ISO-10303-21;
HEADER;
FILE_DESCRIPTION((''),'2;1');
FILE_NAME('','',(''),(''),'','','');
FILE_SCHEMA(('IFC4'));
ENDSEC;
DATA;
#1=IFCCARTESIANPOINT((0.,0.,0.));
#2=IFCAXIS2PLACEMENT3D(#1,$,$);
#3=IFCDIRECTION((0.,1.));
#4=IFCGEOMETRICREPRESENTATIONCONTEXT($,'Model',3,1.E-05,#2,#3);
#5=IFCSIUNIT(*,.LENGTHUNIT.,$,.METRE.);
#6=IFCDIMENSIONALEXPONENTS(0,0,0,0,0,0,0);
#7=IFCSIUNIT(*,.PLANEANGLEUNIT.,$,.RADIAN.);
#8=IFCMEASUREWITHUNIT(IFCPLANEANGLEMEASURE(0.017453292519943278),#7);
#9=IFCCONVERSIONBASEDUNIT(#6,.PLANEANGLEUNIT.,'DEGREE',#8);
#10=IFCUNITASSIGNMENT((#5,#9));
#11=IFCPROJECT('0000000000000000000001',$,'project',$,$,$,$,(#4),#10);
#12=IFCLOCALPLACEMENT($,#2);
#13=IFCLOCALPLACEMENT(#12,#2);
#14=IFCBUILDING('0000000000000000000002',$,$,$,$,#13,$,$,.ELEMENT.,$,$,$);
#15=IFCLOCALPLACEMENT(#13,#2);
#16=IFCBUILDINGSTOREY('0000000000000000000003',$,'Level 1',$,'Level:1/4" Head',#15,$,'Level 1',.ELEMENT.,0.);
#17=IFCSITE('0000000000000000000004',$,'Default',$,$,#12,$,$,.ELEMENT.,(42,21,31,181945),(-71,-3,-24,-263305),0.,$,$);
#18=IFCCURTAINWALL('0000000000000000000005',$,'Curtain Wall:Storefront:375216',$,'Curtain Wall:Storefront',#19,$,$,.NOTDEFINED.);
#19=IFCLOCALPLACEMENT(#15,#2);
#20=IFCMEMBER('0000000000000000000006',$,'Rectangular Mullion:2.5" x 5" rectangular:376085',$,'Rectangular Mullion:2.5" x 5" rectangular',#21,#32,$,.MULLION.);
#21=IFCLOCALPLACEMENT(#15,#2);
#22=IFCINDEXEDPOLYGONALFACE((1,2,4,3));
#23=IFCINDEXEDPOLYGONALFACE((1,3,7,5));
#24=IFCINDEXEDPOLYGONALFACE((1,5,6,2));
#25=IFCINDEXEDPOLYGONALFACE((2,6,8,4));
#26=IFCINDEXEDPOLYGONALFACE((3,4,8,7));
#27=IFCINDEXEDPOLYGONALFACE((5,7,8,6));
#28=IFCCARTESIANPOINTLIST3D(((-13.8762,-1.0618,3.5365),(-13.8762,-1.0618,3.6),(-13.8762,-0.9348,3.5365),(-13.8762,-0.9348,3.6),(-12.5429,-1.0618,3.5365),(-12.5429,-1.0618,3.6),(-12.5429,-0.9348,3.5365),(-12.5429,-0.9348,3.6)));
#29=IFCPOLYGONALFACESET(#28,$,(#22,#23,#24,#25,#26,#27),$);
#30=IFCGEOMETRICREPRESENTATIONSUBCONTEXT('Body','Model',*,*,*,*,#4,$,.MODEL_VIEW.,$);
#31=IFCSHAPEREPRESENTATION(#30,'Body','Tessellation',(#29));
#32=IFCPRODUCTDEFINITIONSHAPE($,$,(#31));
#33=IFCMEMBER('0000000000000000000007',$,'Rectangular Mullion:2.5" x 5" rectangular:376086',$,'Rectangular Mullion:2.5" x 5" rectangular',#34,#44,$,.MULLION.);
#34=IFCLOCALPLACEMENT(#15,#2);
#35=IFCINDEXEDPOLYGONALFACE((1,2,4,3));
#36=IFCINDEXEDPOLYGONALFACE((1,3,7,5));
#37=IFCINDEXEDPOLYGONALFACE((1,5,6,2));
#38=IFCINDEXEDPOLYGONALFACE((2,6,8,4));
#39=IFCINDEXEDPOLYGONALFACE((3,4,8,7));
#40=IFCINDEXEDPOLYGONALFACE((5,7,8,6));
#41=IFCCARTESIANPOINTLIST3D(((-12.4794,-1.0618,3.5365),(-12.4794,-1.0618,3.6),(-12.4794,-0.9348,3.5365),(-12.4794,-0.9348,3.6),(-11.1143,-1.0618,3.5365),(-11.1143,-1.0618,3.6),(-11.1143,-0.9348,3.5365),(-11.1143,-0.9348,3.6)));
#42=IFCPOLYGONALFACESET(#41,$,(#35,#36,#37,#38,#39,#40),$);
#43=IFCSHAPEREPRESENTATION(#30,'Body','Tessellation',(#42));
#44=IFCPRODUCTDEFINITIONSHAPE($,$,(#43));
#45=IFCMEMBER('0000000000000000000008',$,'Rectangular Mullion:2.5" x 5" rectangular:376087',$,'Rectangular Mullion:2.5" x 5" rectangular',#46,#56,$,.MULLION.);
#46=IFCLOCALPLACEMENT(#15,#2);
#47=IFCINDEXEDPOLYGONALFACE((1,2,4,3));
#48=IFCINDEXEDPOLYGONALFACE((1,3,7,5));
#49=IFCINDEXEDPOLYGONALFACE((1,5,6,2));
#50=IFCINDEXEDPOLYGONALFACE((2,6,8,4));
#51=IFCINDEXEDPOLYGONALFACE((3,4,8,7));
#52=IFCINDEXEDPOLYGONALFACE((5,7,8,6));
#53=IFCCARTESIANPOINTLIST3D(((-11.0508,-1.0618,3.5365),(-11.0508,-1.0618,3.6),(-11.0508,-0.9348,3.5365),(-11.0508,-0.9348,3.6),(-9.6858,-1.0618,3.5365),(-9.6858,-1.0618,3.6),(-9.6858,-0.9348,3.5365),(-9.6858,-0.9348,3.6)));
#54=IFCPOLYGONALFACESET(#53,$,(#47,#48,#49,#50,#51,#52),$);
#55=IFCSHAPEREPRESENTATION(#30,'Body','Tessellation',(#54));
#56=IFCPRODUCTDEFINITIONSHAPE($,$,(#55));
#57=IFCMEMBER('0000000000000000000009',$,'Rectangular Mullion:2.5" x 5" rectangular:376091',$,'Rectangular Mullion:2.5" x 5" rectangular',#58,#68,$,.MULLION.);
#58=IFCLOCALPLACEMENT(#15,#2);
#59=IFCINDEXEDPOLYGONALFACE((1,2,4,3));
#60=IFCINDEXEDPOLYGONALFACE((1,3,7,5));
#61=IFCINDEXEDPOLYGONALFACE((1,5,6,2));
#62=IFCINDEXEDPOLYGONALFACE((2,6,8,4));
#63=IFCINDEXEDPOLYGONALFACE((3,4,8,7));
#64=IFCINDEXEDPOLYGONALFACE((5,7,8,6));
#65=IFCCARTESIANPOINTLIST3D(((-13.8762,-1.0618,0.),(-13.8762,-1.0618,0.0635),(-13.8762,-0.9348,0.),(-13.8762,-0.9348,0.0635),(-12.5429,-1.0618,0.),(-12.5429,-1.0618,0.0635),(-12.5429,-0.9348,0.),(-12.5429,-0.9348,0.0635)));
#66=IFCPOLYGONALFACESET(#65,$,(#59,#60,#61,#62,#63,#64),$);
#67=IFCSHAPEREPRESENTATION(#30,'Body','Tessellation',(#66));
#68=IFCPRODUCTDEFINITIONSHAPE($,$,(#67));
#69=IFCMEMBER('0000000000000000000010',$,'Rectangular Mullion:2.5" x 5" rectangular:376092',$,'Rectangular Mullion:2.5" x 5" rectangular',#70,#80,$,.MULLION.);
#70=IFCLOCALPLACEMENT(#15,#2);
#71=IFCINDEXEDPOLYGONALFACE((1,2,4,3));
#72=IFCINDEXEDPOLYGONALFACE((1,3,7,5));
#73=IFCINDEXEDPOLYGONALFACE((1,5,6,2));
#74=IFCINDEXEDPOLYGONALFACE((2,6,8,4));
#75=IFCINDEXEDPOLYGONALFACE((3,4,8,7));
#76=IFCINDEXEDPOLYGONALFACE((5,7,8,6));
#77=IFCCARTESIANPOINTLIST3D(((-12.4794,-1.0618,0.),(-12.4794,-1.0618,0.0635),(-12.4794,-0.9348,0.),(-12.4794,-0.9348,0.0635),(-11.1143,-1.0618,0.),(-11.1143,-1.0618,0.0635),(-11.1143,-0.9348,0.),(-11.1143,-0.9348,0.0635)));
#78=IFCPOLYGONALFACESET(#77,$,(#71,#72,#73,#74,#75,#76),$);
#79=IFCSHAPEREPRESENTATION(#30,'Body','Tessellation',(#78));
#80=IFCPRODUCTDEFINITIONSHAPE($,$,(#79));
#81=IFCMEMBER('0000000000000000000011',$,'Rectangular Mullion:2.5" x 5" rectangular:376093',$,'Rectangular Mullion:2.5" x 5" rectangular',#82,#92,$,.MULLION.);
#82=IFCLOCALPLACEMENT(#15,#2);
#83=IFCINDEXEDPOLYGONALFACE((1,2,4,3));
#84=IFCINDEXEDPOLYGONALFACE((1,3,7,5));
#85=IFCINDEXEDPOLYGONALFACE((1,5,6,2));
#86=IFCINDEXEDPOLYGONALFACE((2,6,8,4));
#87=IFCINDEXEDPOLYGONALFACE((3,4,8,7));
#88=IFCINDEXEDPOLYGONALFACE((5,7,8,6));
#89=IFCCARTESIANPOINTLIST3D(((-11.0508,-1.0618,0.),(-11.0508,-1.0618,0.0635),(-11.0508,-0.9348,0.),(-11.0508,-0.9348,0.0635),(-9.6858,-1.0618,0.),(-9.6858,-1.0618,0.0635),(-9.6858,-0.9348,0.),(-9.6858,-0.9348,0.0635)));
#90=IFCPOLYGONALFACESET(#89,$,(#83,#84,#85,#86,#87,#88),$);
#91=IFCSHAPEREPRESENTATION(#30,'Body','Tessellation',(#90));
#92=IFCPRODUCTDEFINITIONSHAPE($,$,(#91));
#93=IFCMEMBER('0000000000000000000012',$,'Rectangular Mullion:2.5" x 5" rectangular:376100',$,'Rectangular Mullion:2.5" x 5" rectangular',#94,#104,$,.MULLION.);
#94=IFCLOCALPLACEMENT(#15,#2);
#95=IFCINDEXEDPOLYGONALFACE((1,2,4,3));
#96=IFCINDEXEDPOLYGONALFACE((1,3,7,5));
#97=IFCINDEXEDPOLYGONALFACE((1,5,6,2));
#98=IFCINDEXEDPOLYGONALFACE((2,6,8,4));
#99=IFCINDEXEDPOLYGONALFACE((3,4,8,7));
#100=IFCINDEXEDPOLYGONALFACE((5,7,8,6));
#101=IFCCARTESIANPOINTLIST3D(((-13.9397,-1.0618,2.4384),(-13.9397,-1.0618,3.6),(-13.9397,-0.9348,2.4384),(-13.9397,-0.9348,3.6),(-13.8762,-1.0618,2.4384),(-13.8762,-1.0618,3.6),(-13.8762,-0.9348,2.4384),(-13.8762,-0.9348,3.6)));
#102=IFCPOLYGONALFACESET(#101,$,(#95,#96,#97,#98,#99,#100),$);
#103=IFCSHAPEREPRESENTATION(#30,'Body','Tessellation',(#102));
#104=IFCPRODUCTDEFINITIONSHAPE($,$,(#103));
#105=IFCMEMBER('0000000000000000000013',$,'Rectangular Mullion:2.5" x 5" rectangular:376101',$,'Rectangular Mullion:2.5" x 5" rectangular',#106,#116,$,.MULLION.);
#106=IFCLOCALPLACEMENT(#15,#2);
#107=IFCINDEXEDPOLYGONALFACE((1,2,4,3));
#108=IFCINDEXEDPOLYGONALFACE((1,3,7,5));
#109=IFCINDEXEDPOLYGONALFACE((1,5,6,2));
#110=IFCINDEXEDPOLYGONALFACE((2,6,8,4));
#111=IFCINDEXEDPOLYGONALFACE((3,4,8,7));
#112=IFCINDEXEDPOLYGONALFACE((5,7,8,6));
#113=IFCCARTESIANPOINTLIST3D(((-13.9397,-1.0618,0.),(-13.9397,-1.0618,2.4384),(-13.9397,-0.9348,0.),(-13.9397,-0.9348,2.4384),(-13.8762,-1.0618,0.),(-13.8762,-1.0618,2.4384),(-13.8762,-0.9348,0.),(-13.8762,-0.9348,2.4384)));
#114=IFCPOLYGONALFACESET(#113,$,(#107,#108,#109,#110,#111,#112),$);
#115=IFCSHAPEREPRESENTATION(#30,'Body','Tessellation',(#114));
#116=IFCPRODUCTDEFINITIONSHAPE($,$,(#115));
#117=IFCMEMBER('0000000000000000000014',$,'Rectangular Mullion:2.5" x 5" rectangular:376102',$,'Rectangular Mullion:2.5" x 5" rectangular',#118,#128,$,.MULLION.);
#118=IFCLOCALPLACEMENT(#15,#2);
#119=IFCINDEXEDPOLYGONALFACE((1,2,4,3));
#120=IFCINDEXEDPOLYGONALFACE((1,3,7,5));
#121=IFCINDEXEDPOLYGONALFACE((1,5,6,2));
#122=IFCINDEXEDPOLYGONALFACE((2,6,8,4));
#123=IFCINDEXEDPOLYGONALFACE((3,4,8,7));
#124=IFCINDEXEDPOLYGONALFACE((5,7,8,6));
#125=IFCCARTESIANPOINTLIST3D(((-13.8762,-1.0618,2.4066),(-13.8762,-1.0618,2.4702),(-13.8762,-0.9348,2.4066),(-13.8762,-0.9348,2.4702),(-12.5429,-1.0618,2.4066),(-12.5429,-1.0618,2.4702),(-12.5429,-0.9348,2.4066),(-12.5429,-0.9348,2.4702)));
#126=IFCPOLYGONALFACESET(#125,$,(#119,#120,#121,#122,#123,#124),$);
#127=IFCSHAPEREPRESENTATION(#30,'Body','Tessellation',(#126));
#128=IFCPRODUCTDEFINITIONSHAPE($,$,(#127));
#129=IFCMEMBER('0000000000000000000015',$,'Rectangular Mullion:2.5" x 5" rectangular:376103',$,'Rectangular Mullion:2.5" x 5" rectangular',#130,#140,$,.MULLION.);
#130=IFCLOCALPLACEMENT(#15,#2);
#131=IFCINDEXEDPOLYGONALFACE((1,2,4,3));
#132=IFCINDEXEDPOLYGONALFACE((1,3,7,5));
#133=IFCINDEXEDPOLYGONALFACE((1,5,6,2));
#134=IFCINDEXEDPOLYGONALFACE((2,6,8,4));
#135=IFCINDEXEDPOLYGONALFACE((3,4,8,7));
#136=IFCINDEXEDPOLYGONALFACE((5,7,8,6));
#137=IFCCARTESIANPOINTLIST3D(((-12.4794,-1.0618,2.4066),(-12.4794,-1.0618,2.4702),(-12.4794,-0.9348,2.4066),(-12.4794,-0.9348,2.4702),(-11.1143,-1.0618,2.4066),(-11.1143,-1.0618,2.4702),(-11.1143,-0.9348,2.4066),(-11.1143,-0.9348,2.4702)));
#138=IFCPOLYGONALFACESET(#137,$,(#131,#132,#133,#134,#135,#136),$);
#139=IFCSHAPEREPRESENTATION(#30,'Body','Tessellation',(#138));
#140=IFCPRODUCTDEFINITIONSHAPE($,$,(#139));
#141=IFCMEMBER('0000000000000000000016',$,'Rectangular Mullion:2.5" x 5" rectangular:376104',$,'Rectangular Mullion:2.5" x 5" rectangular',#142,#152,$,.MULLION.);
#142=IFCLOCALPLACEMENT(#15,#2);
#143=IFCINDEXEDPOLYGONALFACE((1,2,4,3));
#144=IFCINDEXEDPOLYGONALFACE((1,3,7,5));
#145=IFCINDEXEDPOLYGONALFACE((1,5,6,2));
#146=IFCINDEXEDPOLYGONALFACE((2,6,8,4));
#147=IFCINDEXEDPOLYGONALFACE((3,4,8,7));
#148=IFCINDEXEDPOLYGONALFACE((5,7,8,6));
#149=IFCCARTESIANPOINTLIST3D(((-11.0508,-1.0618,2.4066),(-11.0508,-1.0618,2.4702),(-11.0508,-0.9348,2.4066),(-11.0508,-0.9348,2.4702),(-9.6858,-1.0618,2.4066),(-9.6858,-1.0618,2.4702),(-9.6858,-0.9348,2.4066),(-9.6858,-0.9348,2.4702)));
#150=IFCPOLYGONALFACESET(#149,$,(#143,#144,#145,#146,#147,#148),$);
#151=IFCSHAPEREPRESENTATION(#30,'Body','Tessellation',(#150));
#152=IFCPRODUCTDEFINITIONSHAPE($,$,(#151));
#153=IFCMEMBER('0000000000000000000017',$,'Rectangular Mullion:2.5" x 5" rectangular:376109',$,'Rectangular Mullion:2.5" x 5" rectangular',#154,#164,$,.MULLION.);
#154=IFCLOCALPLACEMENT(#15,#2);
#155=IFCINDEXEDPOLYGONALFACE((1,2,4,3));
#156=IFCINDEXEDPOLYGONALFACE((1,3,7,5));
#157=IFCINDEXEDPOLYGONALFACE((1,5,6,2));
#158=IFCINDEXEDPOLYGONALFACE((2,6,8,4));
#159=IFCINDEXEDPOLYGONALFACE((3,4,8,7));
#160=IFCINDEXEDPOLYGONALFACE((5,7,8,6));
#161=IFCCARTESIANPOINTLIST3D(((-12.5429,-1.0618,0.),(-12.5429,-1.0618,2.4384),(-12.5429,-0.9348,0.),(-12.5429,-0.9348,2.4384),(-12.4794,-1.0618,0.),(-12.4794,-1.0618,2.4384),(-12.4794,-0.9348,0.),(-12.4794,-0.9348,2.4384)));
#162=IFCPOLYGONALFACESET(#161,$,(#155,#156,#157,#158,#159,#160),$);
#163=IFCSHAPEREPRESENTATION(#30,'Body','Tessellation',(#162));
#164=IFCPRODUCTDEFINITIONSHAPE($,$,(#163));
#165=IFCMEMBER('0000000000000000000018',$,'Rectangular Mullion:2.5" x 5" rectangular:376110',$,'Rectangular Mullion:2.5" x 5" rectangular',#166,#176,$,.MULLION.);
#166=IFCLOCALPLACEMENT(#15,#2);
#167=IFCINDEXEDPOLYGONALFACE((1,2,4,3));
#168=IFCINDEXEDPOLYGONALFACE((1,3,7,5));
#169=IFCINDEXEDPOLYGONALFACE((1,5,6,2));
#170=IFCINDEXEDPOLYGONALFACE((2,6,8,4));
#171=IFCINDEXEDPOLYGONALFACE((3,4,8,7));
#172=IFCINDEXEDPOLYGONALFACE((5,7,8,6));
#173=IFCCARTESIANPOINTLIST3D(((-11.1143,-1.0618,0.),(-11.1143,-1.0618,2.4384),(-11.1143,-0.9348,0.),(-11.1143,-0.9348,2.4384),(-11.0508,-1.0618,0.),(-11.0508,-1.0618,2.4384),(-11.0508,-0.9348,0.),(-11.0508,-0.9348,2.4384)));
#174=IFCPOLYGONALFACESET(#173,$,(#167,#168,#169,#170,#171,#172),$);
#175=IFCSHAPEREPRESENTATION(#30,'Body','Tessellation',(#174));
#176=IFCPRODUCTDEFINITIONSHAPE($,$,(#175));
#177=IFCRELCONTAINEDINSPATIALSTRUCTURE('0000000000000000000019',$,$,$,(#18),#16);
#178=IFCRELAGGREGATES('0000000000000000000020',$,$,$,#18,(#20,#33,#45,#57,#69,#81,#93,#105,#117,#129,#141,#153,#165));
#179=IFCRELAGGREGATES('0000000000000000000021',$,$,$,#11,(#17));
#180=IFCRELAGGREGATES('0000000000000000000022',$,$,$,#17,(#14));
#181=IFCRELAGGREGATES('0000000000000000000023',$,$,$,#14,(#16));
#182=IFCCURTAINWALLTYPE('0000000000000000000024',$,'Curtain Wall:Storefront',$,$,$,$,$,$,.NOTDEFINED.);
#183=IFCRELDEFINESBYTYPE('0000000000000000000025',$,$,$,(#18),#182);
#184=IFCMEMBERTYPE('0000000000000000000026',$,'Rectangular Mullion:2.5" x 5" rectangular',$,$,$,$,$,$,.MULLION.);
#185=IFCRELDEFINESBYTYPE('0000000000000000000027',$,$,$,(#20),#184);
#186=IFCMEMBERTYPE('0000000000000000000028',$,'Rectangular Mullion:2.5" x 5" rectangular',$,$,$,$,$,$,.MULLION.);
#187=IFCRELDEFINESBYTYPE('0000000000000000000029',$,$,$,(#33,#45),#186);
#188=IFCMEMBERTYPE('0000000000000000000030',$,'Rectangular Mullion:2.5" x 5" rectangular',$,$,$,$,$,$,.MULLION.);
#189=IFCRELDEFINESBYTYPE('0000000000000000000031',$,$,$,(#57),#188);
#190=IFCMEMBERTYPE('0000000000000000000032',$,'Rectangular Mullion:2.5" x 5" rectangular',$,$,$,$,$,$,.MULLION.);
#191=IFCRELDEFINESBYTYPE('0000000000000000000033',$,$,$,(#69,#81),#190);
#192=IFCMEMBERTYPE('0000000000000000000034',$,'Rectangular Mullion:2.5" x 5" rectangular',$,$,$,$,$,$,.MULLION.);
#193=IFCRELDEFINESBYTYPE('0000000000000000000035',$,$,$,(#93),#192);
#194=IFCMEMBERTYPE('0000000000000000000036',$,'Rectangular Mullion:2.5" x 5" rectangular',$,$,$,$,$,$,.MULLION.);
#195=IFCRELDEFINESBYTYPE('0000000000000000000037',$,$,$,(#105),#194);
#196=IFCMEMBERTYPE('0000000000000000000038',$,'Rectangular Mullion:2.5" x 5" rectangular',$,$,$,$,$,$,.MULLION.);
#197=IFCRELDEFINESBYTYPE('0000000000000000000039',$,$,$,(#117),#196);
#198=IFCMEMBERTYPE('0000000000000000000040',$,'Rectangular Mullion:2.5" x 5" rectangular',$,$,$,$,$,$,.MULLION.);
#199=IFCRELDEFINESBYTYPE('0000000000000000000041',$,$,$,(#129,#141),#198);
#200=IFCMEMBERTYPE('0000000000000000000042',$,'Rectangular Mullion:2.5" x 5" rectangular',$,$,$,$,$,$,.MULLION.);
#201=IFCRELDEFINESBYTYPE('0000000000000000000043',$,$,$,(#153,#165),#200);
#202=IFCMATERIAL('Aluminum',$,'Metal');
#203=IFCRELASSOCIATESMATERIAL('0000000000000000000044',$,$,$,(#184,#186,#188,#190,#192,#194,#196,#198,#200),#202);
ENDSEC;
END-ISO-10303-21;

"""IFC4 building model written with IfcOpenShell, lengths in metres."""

from ifc_helpers import new_model, entity, si_unit, converted_unit, direction, frame, frame_2d, origin, origin_2d_with_axis, place, context, subcontext, project, spatial, rectangle, extrude, source, transform, mapped, material, material_profile, profile_set, type_object, type_shapes, element, aggregate, save


model = new_model("IFC4")

# Units and contexts
model_context = context("Model", 3, precision=1e-05, world=origin(), true_north=direction((0.0, 1.0)))
body_context = subcontext(model_context, "Body", "Model", "MODEL_VIEW")
ifc_project = project(units=[si_unit("LENGTHUNIT", "METRE"), converted_unit("PLANEANGLEUNIT", "DEGREE", entity("IfcPlaneAngleMeasure", 0.017453292519943278), si_unit("PLANEANGLEUNIT", "RADIAN"), dimensions=[0, 0, 0, 0, 0, 0, 0])], contexts=[model_context])

# Site, building, storey
site_placement = place(None, origin())
site = spatial("IfcSite", under=ifc_project, at=site_placement, Name="Default", CompositionType="ELEMENT", RefLatitude=(42, 21, 31, 181945), RefLongitude=(-71, -3, -24, -263305), RefElevation=0.0)
building_placement = place(site_placement, origin())
building = spatial("IfcBuilding", under=site, at=building_placement, CompositionType="ELEMENT")
storey_placement = place(building_placement, origin())
storey = spatial("IfcBuildingStorey", under=building, at=storey_placement, Name="Level 1", ObjectType="Level:1/4\" Head", LongName="Level 1", CompositionType="ELEMENT", Elevation=0.0)

# Curtain wall, members
curtain_wall_type = type_object("IfcCurtainWallType", Name="Curtain Wall:Storefront", PredefinedType="NOTDEFINED")
curtain_wall_placement = place(storey_placement, origin())
curtain_wall = element("IfcCurtainWall", 1, at=curtain_wall_placement, inside=storey, type_object=curtain_wall_type, Name="Curtain Wall:Storefront:375216", ObjectType="Curtain Wall:Storefront", PredefinedType="NOTDEFINED")
ifc_material_1 = material(Name="Aluminum", Category="Metal")
ifc_material_profile = material_profile(ifc_material_1, rectangle(XDim=0.0635, YDim=0.127, at=frame_2d((0.0, 0.0), x_axis=(1.0, 0.0))), Name="2.5\" x 5\" rectangular")
ifc_profile_set = profile_set([ifc_material_profile], Name="2.5\" x 5\" rectangular")
member_type_1 = type_object("IfcMemberType", Name="Rectangular Mullion:2.5\" x 5\" rectangular", PredefinedType="MULLION", material=ifc_profile_set)
shared_shape_1 = source(origin(), body_context, "Body", "SweptSolid", [
    extrude(rectangle(XDim=0.0635, YDim=0.127, at=frame_2d((0.0, 0.0), x_axis=(1.0, 0.0))), frame((-0.0318, 0.0, -1.3333), z_axis=(0.0, 0.0, 1.0), x_axis=(-1.0, 0.0, 0.0)), (0.0, 0.0, 1.0), 1.3333),
])
type_shapes(member_type_1, [shared_shape_1])
member_1_placement = place(curtain_wall_placement, frame((-12.5429, -0.9983, 3.6), z_axis=(1.0, 0.0, 0.0), x_axis=(0.0, 0.0, 1.0)))
member_1 = element("IfcMember", 2, at=member_1_placement, type_object=member_type_1, Name="Rectangular Mullion:2.5\" x 5\" rectangular:376085", ObjectType="Rectangular Mullion:2.5\" x 5\" rectangular", PredefinedType="MULLION", context=body_context, shape_type="MappedRepresentation", body=[
    mapped(shared_shape_1, transform((0.0, 0.0, 0.0), scale=1.0)),
])
member_type_2 = type_object("IfcMemberType", Name="Rectangular Mullion:2.5\" x 5\" rectangular", PredefinedType="MULLION", material=ifc_profile_set)
shared_shape_2 = source(origin(), body_context, "Body", "SweptSolid", [
    extrude(rectangle(XDim=0.0635, YDim=0.127, at=frame_2d((0.0, 0.0), x_axis=(1.0, 0.0))), frame((-0.0318, 0.0, -1.3651), z_axis=(0.0, 0.0, 1.0), x_axis=(-1.0, 0.0, 0.0)), (0.0, 0.0, 1.0), 1.3651),
])
type_shapes(member_type_2, [shared_shape_2])
member_2_placement = place(curtain_wall_placement, frame((-11.1143, -0.9983, 3.6), z_axis=(1.0, 0.0, 0.0), x_axis=(0.0, 0.0, 1.0)))
member_2 = element("IfcMember", 3, at=member_2_placement, type_object=member_type_2, Name="Rectangular Mullion:2.5\" x 5\" rectangular:376086", ObjectType="Rectangular Mullion:2.5\" x 5\" rectangular", PredefinedType="MULLION", context=body_context, shape_type="MappedRepresentation", body=[
    mapped(shared_shape_2, transform((0.0, 0.0, 0.0), scale=1.0)),
])
member_3_placement = place(curtain_wall_placement, frame((-9.6858, -0.9983, 3.6), z_axis=(1.0, 0.0, 0.0), x_axis=(0.0, 0.0, 1.0)))
member_3 = element("IfcMember", 4, at=member_3_placement, type_object=member_type_2, Name="Rectangular Mullion:2.5\" x 5\" rectangular:376087", ObjectType="Rectangular Mullion:2.5\" x 5\" rectangular", PredefinedType="MULLION", context=body_context, shape_type="MappedRepresentation", body=[
    mapped(shared_shape_2, transform((0.0, 0.0, 0.0), scale=1.0)),
])
member_type_3 = type_object("IfcMemberType", Name="Rectangular Mullion:2.5\" x 5\" rectangular", PredefinedType="MULLION", material=ifc_profile_set)
shared_shape_3 = source(origin(), body_context, "Body", "SweptSolid", [
    extrude(rectangle(XDim=0.0635, YDim=0.127, at=frame_2d((0.0, 0.0), x_axis=(1.0, 0.0))), frame((-0.0318, 0.0, -1.3333), z_axis=(0.0, 0.0, 1.0), x_axis=(-1.0, 0.0, 0.0)), (0.0, 0.0, 1.0), 1.3333),
])
type_shapes(member_type_3, [shared_shape_3])
member_4_placement = place(curtain_wall_placement, frame((-13.8762, -0.9983, 0.0), z_axis=(-1.0, 0.0, 0.0), x_axis=(0.0, 0.0, -1.0)))
member_4 = element("IfcMember", 5, at=member_4_placement, type_object=member_type_3, Name="Rectangular Mullion:2.5\" x 5\" rectangular:376091", ObjectType="Rectangular Mullion:2.5\" x 5\" rectangular", PredefinedType="MULLION", context=body_context, shape_type="MappedRepresentation", body=[
    mapped(shared_shape_3, transform((0.0, 0.0, 0.0), scale=1.0)),
])
member_type_4 = type_object("IfcMemberType", Name="Rectangular Mullion:2.5\" x 5\" rectangular", PredefinedType="MULLION", material=ifc_profile_set)
shared_shape_4 = source(origin(), body_context, "Body", "SweptSolid", [
    extrude(rectangle(XDim=0.0635, YDim=0.127, at=frame_2d((0.0, 0.0), x_axis=(1.0, 0.0))), frame((-0.0318, 0.0, -1.3651), z_axis=(0.0, 0.0, 1.0), x_axis=(-1.0, 0.0, 0.0)), (0.0, 0.0, 1.0), 1.3651),
])
type_shapes(member_type_4, [shared_shape_4])
member_5_placement = place(curtain_wall_placement, frame((-12.4794, -0.9983, 0.0), z_axis=(-1.0, 0.0, 0.0), x_axis=(0.0, 0.0, -1.0)))
member_5 = element("IfcMember", 6, at=member_5_placement, type_object=member_type_4, Name="Rectangular Mullion:2.5\" x 5\" rectangular:376092", ObjectType="Rectangular Mullion:2.5\" x 5\" rectangular", PredefinedType="MULLION", context=body_context, shape_type="MappedRepresentation", body=[
    mapped(shared_shape_4, transform((0.0, 0.0, 0.0), scale=1.0)),
])
member_6_placement = place(curtain_wall_placement, frame((-11.0508, -0.9983, 0.0), z_axis=(-1.0, 0.0, 0.0), x_axis=(0.0, 0.0, -1.0)))
member_6 = element("IfcMember", 7, at=member_6_placement, type_object=member_type_4, Name="Rectangular Mullion:2.5\" x 5\" rectangular:376093", ObjectType="Rectangular Mullion:2.5\" x 5\" rectangular", PredefinedType="MULLION", context=body_context, shape_type="MappedRepresentation", body=[
    mapped(shared_shape_4, transform((0.0, 0.0, 0.0), scale=1.0)),
])
member_type_5 = type_object("IfcMemberType", Name="Rectangular Mullion:2.5\" x 5\" rectangular", PredefinedType="MULLION", material=ifc_profile_set)
shared_shape_5 = source(origin(), body_context, "Body", "SweptSolid", [
    extrude(rectangle(XDim=0.0635, YDim=0.127, at=frame_2d((0.0, 0.0), x_axis=(1.0, 0.0))), frame((-0.0318, 0.0, -1.1616), z_axis=(0.0, 0.0, 1.0), x_axis=(-1.0, 0.0, 0.0)), (0.0, 0.0, 1.0), 1.1616),
])
type_shapes(member_type_5, [shared_shape_5])
member_7_placement = place(curtain_wall_placement, frame((-13.9397, -0.9983, 3.6), z_axis=(0.0, 0.0, 1.0), x_axis=(-1.0, 0.0, 0.0)))
member_7 = element("IfcMember", 8, at=member_7_placement, type_object=member_type_5, Name="Rectangular Mullion:2.5\" x 5\" rectangular:376100", ObjectType="Rectangular Mullion:2.5\" x 5\" rectangular", PredefinedType="MULLION", context=body_context, shape_type="MappedRepresentation", body=[
    mapped(shared_shape_5, transform((0.0, 0.0, 0.0), scale=1.0)),
])
member_type_6 = type_object("IfcMemberType", Name="Rectangular Mullion:2.5\" x 5\" rectangular", PredefinedType="MULLION", material=ifc_profile_set)
shared_shape_6 = source(origin(), body_context, "Body", "SweptSolid", [
    extrude(rectangle(XDim=0.0635, YDim=0.127, at=frame_2d((0.0, 0.0), x_axis=(1.0, 0.0))), frame((-0.0318, 0.0, -2.4384), z_axis=(0.0, 0.0, 1.0), x_axis=(-1.0, 0.0, 0.0)), (0.0, 0.0, 1.0), 2.4384),
])
type_shapes(member_type_6, [shared_shape_6])
member_8_placement = place(curtain_wall_placement, frame((-13.9397, -0.9983, 2.4384), z_axis=(0.0, 0.0, 1.0), x_axis=(-1.0, 0.0, 0.0)))
member_8 = element("IfcMember", 9, at=member_8_placement, type_object=member_type_6, Name="Rectangular Mullion:2.5\" x 5\" rectangular:376101", ObjectType="Rectangular Mullion:2.5\" x 5\" rectangular", PredefinedType="MULLION", context=body_context, shape_type="MappedRepresentation", body=[
    mapped(shared_shape_6, transform((0.0, 0.0, 0.0), scale=1.0)),
])
member_type_7 = type_object("IfcMemberType", Name="Rectangular Mullion:2.5\" x 5\" rectangular", PredefinedType="MULLION", material=ifc_profile_set)
shared_shape_7 = source(origin(), body_context, "Body", "SweptSolid", [
    extrude(rectangle(XDim=0.0635, YDim=0.127, at=origin_2d_with_axis()), frame((0.0, 0.0, -1.3333), z_axis=(0.0, 0.0, 1.0), x_axis=(-1.0, 0.0, 0.0)), (0.0, 0.0, 1.0), 1.3333),
])
type_shapes(member_type_7, [shared_shape_7])
member_9_placement = place(curtain_wall_placement, frame((-12.5429, -0.9983, 2.4384), z_axis=(1.0, 0.0, 0.0), x_axis=(0.0, 0.0, 1.0)))
member_9 = element("IfcMember", 10, at=member_9_placement, type_object=member_type_7, Name="Rectangular Mullion:2.5\" x 5\" rectangular:376102", ObjectType="Rectangular Mullion:2.5\" x 5\" rectangular", PredefinedType="MULLION", context=body_context, shape_type="MappedRepresentation", body=[
    mapped(shared_shape_7, transform((0.0, 0.0, 0.0), scale=1.0)),
])
member_type_8 = type_object("IfcMemberType", Name="Rectangular Mullion:2.5\" x 5\" rectangular", PredefinedType="MULLION", material=ifc_profile_set)
shared_shape_8 = source(origin(), body_context, "Body", "SweptSolid", [
    extrude(rectangle(XDim=0.0635, YDim=0.127, at=origin_2d_with_axis()), frame((0.0, 0.0, -1.3651), z_axis=(0.0, 0.0, 1.0), x_axis=(-1.0, 0.0, 0.0)), (0.0, 0.0, 1.0), 1.3651),
])
type_shapes(member_type_8, [shared_shape_8])
member_10_placement = place(curtain_wall_placement, frame((-11.1143, -0.9983, 2.4384), z_axis=(1.0, 0.0, 0.0), x_axis=(0.0, 0.0, 1.0)))
member_10 = element("IfcMember", 11, at=member_10_placement, type_object=member_type_8, Name="Rectangular Mullion:2.5\" x 5\" rectangular:376103", ObjectType="Rectangular Mullion:2.5\" x 5\" rectangular", PredefinedType="MULLION", context=body_context, shape_type="MappedRepresentation", body=[
    mapped(shared_shape_8, transform((0.0, 0.0, 0.0), scale=1.0)),
])
member_11_placement = place(curtain_wall_placement, frame((-9.6858, -0.9983, 2.4384), z_axis=(1.0, 0.0, 0.0), x_axis=(0.0, 0.0, 1.0)))
member_11 = element("IfcMember", 12, at=member_11_placement, type_object=member_type_8, Name="Rectangular Mullion:2.5\" x 5\" rectangular:376104", ObjectType="Rectangular Mullion:2.5\" x 5\" rectangular", PredefinedType="MULLION", context=body_context, shape_type="MappedRepresentation", body=[
    mapped(shared_shape_8, transform((0.0, 0.0, 0.0), scale=1.0)),
])
member_type_9 = type_object("IfcMemberType", Name="Rectangular Mullion:2.5\" x 5\" rectangular", PredefinedType="MULLION", material=ifc_profile_set)
shared_shape_9 = source(origin(), body_context, "Body", "SweptSolid", [
    extrude(rectangle(XDim=0.0635, YDim=0.127, at=origin_2d_with_axis()), frame((0.0, 0.0, -2.4384), z_axis=(0.0, 0.0, 1.0), x_axis=(-1.0, 0.0, 0.0)), (0.0, 0.0, 1.0), 2.4384),
])
type_shapes(member_type_9, [shared_shape_9])
member_12_placement = place(curtain_wall_placement, frame((-12.5112, -0.9983, 0.0), z_axis=(0.0, 0.0, -1.0), x_axis=(1.0, 0.0, 0.0)))
member_12 = element("IfcMember", 13, at=member_12_placement, type_object=member_type_9, Name="Rectangular Mullion:2.5\" x 5\" rectangular:376109", ObjectType="Rectangular Mullion:2.5\" x 5\" rectangular", PredefinedType="MULLION", context=body_context, shape_type="MappedRepresentation", body=[
    mapped(shared_shape_9, transform((0.0, 0.0, 0.0), scale=1.0)),
])
member_13_placement = place(curtain_wall_placement, frame((-11.0826, -0.9983, 0.0), z_axis=(0.0, 0.0, -1.0), x_axis=(1.0, 0.0, 0.0)))
member_13 = element("IfcMember", 14, at=member_13_placement, type_object=member_type_9, Name="Rectangular Mullion:2.5\" x 5\" rectangular:376110", ObjectType="Rectangular Mullion:2.5\" x 5\" rectangular", PredefinedType="MULLION", context=body_context, shape_type="MappedRepresentation", body=[
    mapped(shared_shape_9, transform((0.0, 0.0, 0.0), scale=1.0)),
])
aggregate(curtain_wall, [member_1, member_2, member_3, member_4, member_5, member_6, member_7, member_8, member_9, member_10, member_11, member_12, member_13])

save(model, "model.ifc")
